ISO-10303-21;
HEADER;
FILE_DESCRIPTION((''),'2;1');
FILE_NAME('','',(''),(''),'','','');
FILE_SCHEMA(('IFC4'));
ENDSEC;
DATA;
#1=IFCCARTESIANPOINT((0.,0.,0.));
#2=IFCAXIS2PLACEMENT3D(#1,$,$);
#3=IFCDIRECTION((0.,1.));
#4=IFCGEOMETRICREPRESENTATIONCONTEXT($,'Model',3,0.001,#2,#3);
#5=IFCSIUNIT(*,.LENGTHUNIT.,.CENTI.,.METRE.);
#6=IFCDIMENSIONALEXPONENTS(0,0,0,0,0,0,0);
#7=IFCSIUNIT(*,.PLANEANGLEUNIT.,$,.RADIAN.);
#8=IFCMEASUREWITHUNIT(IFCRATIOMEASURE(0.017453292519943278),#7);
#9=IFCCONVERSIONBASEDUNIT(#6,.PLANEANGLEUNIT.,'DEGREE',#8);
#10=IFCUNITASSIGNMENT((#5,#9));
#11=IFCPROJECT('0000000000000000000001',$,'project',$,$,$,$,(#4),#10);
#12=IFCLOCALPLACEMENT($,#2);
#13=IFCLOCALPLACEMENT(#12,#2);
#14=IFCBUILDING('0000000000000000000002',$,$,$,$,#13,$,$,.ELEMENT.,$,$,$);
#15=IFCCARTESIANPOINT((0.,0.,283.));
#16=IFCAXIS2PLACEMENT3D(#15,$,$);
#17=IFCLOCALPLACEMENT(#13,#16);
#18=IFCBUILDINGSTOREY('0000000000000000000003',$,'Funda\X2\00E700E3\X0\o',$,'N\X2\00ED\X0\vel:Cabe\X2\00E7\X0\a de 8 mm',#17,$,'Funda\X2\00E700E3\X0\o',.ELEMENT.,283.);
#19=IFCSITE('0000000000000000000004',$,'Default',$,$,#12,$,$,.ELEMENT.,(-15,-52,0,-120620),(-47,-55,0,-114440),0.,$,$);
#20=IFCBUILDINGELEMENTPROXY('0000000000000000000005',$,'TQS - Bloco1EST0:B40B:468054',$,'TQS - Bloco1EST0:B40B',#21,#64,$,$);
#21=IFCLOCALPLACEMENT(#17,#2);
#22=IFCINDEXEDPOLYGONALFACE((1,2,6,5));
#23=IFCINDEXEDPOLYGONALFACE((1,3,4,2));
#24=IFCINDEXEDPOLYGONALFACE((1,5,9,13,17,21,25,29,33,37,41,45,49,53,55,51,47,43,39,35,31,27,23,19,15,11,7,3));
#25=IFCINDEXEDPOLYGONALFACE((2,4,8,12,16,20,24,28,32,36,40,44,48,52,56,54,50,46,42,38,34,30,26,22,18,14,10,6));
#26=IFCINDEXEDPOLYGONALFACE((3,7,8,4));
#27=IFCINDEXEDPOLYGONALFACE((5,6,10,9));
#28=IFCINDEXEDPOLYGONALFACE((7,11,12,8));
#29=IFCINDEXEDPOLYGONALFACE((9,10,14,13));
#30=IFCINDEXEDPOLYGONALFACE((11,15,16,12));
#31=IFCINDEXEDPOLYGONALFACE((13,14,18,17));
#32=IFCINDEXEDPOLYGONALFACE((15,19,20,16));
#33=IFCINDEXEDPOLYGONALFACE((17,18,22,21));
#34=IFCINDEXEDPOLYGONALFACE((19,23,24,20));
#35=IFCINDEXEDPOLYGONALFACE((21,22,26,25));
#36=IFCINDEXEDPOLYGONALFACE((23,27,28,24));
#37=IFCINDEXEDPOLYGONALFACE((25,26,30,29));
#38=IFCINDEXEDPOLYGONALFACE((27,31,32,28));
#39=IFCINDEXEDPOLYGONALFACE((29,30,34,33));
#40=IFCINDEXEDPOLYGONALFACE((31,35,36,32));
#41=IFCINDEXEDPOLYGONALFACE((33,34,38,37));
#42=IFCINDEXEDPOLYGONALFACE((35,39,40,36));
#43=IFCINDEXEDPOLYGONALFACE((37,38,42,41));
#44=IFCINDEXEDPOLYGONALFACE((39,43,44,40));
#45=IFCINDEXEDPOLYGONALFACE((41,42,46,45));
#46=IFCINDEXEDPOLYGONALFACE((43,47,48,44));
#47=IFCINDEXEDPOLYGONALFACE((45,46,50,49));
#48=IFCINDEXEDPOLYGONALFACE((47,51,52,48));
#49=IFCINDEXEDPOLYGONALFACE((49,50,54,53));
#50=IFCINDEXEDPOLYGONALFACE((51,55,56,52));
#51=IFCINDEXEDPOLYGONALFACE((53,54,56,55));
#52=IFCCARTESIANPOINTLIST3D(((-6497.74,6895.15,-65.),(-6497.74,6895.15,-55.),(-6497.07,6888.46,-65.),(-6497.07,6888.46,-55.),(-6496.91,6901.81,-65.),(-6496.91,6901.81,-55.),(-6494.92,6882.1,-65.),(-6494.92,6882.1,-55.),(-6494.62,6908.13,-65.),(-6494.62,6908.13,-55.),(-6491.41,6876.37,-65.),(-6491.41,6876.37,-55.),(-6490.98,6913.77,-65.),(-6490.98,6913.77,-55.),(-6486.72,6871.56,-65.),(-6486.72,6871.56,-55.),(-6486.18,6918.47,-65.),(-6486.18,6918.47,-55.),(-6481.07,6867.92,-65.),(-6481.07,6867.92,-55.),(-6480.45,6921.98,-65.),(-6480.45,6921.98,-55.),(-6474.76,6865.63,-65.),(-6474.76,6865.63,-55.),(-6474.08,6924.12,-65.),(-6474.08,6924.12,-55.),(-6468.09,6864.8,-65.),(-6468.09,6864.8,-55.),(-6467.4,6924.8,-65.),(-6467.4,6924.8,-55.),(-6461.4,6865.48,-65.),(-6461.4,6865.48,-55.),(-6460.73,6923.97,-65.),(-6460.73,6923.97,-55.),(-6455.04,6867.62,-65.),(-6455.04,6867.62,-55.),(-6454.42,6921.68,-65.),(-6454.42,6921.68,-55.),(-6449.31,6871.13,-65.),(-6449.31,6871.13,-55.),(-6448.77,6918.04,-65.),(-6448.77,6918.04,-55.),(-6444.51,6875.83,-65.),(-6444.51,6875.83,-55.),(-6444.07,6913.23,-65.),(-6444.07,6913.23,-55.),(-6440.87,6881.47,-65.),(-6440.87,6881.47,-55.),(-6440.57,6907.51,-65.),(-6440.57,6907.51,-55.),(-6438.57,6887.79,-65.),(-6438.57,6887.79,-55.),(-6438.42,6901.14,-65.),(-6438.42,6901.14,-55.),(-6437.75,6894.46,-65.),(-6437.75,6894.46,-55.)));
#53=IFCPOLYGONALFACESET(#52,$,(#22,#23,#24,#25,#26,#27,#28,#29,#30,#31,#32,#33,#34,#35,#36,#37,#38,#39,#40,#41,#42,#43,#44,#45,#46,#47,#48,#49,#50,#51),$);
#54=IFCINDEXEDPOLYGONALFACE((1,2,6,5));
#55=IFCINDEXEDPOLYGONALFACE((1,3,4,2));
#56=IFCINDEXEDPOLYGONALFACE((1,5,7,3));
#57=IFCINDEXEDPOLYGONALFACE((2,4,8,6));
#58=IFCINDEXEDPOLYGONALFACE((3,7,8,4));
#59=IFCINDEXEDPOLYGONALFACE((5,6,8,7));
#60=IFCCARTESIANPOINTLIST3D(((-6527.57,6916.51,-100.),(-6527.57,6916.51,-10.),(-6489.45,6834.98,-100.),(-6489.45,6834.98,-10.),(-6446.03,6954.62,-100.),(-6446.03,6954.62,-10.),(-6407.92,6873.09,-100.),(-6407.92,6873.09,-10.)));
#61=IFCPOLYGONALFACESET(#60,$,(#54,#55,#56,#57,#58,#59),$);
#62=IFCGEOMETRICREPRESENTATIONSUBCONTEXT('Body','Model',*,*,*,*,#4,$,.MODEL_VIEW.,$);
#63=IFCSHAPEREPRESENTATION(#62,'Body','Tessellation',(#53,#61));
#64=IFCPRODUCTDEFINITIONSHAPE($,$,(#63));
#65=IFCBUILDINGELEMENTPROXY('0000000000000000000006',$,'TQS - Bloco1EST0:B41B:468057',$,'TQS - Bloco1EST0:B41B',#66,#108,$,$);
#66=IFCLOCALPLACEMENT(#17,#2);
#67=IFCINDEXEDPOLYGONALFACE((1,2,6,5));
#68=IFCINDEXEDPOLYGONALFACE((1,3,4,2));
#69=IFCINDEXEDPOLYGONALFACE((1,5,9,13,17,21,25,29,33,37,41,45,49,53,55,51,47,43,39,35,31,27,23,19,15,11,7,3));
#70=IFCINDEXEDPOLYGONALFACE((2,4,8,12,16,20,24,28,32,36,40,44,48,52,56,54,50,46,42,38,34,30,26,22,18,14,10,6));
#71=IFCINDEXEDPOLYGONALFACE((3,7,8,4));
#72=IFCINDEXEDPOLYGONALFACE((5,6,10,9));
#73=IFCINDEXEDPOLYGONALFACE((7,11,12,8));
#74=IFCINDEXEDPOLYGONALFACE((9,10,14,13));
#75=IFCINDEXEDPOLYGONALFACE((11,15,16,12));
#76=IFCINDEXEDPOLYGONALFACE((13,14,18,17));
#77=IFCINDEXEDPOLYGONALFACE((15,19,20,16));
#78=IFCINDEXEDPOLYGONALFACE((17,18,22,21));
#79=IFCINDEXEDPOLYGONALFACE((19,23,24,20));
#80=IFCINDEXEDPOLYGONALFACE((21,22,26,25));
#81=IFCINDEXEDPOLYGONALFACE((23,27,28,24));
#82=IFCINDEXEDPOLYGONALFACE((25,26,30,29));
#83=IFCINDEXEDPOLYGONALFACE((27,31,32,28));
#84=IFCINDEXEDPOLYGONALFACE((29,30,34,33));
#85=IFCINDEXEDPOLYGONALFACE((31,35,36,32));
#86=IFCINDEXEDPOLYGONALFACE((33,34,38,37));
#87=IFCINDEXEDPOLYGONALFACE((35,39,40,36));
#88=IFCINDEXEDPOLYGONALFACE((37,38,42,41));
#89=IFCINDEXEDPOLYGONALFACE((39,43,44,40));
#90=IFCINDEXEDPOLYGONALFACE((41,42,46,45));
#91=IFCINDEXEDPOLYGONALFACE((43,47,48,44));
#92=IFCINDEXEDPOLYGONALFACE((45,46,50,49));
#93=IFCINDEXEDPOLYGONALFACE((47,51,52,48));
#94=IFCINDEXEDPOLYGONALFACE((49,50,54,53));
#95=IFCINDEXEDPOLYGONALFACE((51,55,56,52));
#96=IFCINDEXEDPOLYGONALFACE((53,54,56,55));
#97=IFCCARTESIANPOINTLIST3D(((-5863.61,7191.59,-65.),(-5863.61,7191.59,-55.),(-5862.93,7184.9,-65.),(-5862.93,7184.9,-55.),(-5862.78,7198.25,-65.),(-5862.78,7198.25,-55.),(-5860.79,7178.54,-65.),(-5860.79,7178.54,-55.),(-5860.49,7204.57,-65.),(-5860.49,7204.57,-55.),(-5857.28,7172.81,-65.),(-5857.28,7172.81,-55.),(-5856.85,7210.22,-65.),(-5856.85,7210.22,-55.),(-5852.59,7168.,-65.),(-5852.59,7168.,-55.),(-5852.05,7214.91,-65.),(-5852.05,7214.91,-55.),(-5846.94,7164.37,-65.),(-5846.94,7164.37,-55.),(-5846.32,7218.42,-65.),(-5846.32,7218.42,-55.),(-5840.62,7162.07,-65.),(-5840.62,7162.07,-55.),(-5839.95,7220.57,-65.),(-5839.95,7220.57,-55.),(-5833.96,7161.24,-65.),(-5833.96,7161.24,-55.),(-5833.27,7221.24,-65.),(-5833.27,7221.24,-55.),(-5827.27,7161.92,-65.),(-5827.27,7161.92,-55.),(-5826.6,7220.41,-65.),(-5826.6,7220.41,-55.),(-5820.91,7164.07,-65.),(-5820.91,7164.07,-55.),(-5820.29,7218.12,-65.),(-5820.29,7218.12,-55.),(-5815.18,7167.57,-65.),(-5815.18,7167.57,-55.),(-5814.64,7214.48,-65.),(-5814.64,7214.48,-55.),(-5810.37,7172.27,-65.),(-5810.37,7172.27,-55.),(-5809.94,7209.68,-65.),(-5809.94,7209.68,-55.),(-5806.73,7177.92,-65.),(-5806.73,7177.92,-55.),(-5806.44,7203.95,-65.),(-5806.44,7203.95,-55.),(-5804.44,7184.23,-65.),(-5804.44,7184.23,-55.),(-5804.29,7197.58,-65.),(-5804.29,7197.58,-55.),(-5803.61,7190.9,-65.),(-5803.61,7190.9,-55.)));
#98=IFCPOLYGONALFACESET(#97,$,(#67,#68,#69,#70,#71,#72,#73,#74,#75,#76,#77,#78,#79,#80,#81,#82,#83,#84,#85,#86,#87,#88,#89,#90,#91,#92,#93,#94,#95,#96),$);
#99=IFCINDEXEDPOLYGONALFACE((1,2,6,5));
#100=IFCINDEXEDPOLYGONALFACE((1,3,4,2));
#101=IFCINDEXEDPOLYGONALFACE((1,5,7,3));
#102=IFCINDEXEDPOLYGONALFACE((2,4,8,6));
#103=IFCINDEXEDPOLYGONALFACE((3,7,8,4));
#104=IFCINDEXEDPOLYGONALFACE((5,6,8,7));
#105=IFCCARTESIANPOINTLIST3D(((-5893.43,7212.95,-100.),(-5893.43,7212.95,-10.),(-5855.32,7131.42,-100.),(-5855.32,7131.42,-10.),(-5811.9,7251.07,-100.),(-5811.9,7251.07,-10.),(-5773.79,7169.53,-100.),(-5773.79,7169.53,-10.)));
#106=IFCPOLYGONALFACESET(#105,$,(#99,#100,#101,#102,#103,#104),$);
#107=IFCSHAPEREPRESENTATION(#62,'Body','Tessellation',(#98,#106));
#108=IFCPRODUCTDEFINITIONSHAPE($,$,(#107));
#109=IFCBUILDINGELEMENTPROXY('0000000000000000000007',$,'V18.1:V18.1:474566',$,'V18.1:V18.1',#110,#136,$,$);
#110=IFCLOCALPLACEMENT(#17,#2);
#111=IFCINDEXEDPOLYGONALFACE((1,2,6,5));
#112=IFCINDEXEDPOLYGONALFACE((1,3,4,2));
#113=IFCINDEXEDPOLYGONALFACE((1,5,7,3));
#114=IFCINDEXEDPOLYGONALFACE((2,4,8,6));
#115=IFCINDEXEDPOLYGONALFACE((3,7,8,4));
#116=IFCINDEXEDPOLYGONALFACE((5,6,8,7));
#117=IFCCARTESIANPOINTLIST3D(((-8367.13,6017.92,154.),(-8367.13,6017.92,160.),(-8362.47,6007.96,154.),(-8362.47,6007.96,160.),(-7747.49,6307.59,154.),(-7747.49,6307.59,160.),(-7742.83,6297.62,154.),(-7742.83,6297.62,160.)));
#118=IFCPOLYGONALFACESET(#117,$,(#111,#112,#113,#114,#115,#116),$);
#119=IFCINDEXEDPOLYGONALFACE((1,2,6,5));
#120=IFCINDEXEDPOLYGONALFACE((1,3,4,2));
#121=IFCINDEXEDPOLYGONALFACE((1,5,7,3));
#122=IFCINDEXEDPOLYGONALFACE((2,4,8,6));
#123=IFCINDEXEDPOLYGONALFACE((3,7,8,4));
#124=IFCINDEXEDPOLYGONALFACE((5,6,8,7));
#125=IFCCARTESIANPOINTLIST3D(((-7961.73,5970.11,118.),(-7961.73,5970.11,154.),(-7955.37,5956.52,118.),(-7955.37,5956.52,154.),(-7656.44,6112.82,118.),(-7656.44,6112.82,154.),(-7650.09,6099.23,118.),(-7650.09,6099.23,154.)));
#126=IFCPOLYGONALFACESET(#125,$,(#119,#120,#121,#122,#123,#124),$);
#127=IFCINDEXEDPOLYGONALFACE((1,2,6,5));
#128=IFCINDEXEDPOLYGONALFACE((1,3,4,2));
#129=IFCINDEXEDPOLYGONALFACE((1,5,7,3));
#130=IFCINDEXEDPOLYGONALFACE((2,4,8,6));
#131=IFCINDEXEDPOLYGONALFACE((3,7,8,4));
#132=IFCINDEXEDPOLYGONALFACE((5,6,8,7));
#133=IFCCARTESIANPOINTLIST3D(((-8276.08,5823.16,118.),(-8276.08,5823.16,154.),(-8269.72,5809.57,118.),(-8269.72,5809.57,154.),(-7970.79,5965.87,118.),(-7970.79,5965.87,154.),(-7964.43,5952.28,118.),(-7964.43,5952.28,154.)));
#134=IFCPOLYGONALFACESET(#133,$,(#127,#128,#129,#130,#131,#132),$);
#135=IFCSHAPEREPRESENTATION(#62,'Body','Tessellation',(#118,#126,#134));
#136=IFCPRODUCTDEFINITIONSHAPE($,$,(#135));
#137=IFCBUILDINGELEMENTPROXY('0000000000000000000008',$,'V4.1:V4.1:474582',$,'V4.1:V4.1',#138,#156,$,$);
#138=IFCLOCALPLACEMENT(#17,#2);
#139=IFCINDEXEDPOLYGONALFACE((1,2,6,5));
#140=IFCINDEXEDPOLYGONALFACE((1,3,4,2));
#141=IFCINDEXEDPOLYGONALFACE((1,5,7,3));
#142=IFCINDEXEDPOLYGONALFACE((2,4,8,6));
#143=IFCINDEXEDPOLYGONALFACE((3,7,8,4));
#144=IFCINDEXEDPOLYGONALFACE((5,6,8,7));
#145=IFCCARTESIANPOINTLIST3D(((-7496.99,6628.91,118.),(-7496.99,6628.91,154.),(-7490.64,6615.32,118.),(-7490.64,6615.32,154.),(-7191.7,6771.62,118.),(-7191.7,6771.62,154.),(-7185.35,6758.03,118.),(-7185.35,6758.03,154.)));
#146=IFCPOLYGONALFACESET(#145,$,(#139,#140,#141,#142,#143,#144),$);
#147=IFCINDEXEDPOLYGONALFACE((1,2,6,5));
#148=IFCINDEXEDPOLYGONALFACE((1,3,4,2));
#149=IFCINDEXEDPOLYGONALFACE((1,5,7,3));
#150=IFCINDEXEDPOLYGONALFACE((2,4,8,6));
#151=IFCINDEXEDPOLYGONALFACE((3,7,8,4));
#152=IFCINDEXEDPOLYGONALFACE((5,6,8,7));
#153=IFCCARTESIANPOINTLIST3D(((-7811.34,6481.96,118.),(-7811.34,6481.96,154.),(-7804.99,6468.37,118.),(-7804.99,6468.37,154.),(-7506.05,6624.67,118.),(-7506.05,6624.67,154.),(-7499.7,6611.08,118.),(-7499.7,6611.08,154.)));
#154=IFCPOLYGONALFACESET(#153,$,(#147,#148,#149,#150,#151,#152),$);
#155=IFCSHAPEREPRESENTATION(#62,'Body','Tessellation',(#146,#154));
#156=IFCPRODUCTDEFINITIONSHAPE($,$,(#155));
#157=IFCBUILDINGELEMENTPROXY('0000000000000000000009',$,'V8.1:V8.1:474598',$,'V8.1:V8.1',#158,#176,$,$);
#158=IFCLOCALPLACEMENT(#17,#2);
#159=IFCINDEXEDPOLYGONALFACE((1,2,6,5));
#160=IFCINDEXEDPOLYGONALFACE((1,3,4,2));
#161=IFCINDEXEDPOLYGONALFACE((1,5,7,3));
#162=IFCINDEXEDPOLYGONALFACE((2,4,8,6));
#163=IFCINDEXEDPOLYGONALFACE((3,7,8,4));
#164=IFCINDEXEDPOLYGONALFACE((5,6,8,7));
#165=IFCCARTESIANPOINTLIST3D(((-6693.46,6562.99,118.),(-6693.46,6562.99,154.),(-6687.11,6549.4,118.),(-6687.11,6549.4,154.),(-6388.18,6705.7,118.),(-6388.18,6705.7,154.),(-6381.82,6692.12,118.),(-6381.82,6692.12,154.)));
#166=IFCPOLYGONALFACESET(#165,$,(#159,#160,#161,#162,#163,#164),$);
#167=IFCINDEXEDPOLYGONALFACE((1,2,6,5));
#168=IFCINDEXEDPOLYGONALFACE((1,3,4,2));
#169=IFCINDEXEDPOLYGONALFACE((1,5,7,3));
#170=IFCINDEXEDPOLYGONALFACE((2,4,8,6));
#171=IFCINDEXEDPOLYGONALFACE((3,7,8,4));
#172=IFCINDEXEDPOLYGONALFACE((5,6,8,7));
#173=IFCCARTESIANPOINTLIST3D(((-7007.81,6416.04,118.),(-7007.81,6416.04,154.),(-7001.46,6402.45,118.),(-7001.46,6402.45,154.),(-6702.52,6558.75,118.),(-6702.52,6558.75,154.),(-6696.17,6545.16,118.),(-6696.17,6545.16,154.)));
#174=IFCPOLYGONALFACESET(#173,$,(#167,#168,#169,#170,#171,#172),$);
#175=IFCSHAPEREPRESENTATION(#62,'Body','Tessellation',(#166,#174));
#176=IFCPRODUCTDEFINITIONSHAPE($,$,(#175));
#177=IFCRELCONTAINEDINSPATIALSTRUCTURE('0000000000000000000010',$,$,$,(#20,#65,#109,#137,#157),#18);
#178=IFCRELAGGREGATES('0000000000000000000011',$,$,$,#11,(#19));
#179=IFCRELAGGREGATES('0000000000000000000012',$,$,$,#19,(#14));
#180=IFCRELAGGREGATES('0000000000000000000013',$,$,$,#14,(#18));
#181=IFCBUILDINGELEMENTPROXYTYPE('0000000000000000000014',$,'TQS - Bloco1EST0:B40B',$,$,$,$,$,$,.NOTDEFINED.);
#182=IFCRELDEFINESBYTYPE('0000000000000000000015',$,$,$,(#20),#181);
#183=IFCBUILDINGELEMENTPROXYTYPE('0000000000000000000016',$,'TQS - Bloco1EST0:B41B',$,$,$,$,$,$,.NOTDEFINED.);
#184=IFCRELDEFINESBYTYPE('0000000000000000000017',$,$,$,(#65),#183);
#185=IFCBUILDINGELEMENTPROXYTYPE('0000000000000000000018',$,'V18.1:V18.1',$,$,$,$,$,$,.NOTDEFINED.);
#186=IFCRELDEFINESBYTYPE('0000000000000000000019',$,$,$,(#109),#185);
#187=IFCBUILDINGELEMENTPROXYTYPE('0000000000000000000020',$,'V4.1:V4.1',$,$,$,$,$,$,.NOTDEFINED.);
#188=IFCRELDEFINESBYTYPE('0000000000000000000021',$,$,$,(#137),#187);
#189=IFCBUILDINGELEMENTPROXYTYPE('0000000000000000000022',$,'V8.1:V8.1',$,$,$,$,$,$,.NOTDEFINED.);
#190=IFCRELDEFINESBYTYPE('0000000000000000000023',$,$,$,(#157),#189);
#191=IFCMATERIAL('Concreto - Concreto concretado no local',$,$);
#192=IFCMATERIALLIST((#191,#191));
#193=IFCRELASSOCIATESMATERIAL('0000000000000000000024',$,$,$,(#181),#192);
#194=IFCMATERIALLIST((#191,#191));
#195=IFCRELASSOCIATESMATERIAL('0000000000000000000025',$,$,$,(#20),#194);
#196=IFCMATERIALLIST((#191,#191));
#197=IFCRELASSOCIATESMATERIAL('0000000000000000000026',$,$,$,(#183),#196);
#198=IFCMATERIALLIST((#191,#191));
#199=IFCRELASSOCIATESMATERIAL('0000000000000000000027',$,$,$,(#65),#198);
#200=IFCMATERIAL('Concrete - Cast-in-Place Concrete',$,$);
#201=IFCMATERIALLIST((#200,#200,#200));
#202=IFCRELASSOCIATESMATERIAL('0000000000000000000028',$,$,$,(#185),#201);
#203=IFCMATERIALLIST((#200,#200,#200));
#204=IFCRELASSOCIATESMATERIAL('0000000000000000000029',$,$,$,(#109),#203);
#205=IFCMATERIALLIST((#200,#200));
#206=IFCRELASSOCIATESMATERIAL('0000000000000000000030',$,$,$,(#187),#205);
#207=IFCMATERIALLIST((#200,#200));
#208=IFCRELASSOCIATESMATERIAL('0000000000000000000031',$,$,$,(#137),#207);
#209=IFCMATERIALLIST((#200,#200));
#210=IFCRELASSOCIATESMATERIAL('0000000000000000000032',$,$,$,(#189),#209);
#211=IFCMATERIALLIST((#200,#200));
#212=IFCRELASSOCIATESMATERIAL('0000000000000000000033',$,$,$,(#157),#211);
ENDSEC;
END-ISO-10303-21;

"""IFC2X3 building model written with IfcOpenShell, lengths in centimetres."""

from ifc_helpers import new_model, entity, si_unit, converted_unit, direction, frame, frame_2d, origin, origin_2d_with_axis, place, context, subcontext, project, spatial, rectangle, circle, extrude, source, transform, mapped, material, material_list, type_object, type_shapes, element, save


model = new_model("IFC2X3")

# Units and contexts
model_context = context("Model", 3, precision=0.001, world=origin(), true_north=direction((0.0, 1.0)))
body_context = subcontext(model_context, "Body", "Model", "MODEL_VIEW")
ifc_project = project(units=[si_unit("LENGTHUNIT", "METRE", prefix="CENTI"), converted_unit("PLANEANGLEUNIT", "DEGREE", entity("IfcRatioMeasure", 0.017453292519943278), si_unit("PLANEANGLEUNIT", "RADIAN"), dimensions=[0, 0, 0, 0, 0, 0, 0])], contexts=[model_context])

# Site, building, storey
site_placement = place(None, origin())
site = spatial("IfcSite", under=ifc_project, at=site_placement, Name="Default", CompositionType="ELEMENT", RefLatitude=(-15, -52, 0, -120620), RefLongitude=(-47, -55, 0, -114440), RefElevation=0.0)
building_placement = place(site_placement, origin())
building = spatial("IfcBuilding", under=site, at=building_placement, CompositionType="ELEMENT")
storey_placement = place(building_placement, frame((0.0, 0.0, 283.0)))
storey = spatial("IfcBuildingStorey", under=building, at=storey_placement, Name="Fundação", ObjectType="Nível:Cabeça de 8 mm", LongName="Fundação", CompositionType="ELEMENT", Elevation=283.0)

# Building element proxies
ifc_material_1 = material(Name="Concreto - Concreto concretado no local")
ifc_material_list_1 = material_list([ifc_material_1, ifc_material_1])
ifc_material_list_2 = material_list([ifc_material_1, ifc_material_1])
building_element_proxy_type_1 = type_object("IfcBuildingElementProxyType", Name="TQS - Bloco1EST0:B40B", PredefinedType="NOTDEFINED", material=ifc_material_list_2)
shared_shape_1 = source(origin(), body_context, "Body", "SweptSolid", [
    extrude(circle(Radius=30.0, at=frame_2d((0.0, 0.0), x_axis=(1.0, 0.0))), frame((0.0, 0.0, -55.0)), (0.0, 0.0, 1.0), 10.0),
    extrude(rectangle(XDim=90.0, YDim=90.0, at=origin_2d_with_axis()), frame((0.0, 0.0, -90.0), z_axis=(0.0, 0.0, 1.0), x_axis=(-1.0, 0.0, 0.0)), (0.0, 0.0, 1.0), 90.0),
])
type_shapes(building_element_proxy_type_1, [shared_shape_1])
proxy_1_placement = place(storey_placement, frame((-6467.74, 6894.8, -10.0), z_axis=(0.0, 0.0, 1.0), x_axis=(0.905902, 0.423488, 0.0)))
element("IfcBuildingElementProxy", 1, at=proxy_1_placement, inside=storey, type_object=building_element_proxy_type_1, material=ifc_material_list_1, Name="TQS - Bloco1EST0:B40B:468054", ObjectType="TQS - Bloco1EST0:B40B", context=body_context, shape_type="MappedRepresentation", body=[
    mapped(shared_shape_1, transform((0.0, 0.0, 0.0), scale=1.0)),
])
ifc_material_list_3 = material_list([ifc_material_1, ifc_material_1])
ifc_material_list_4 = material_list([ifc_material_1, ifc_material_1])
building_element_proxy_type_2 = type_object("IfcBuildingElementProxyType", Name="TQS - Bloco1EST0:B41B", PredefinedType="NOTDEFINED", material=ifc_material_list_4)
shared_shape_2 = source(origin(), body_context, "Body", "SweptSolid", [
    extrude(circle(Radius=30.0, at=frame_2d((0.0, 0.0), x_axis=(1.0, 0.0))), frame((0.0, 0.0, -55.0)), (0.0, 0.0, 1.0), 10.0),
    extrude(rectangle(XDim=90.0, YDim=90.0, at=origin_2d_with_axis()), frame((0.0, 0.0, -90.0), z_axis=(0.0, 0.0, 1.0), x_axis=(-1.0, 0.0, 0.0)), (0.0, 0.0, 1.0), 90.0),
])
type_shapes(building_element_proxy_type_2, [shared_shape_2])
proxy_2_placement = place(storey_placement, frame((-5833.61, 7191.24, -10.0), z_axis=(0.0, 0.0, 1.0), x_axis=(0.905902, 0.423488, 0.0)))
element("IfcBuildingElementProxy", 2, at=proxy_2_placement, inside=storey, type_object=building_element_proxy_type_2, material=ifc_material_list_3, Name="TQS - Bloco1EST0:B41B:468057", ObjectType="TQS - Bloco1EST0:B41B", context=body_context, shape_type="MappedRepresentation", body=[
    mapped(shared_shape_2, transform((0.0, 0.0, 0.0), scale=1.0)),
])
ifc_material_2 = material(Name="Concrete - Cast-in-Place Concrete")
ifc_material_list_5 = material_list([ifc_material_2, ifc_material_2, ifc_material_2])
ifc_material_list_6 = material_list([ifc_material_2, ifc_material_2, ifc_material_2])
building_element_proxy_type_3 = type_object("IfcBuildingElementProxyType", Name="V18.1:V18.1", PredefinedType="NOTDEFINED", material=ifc_material_list_6)
shared_shape_3 = source(origin(), body_context, "Body", "SweptSolid", [
    extrude(rectangle(XDim=11.0, YDim=684.0, at=frame_2d((0.0, 0.0), x_axis=(1.0, 0.0))), frame((312.15, 348.21, 36.0), z_axis=(0.0, 0.0, 1.0), x_axis=(0.423488, -0.905902, 0.0)), (0.0, 0.0, 1.0), 6.0),
    extrude(rectangle(XDim=15.0, YDim=337.0, at=frame_2d((0.0, 0.0), x_axis=(1.0, 0.0))), frame((561.22, 225.1, 0.0), z_axis=(0.0, 0.0, 1.0), x_axis=(-0.423488, 0.905902, 0.0)), (0.0, 0.0, 1.0), 36.0),
    extrude(rectangle(XDim=337.0, YDim=15.0, at=frame_2d((0.0, 0.0), x_axis=(1.0, 0.0))), frame((246.87, 78.15, 0.0), z_axis=(0.0, 0.0, 1.0), x_axis=(-0.905902, -0.423488, 0.0)), (0.0, 0.0, 1.0), 36.0),
])
type_shapes(building_element_proxy_type_3, [shared_shape_3])
proxy_3_placement = place(storey_placement, frame((-8367.13, 5809.57, 118.0)))
element("IfcBuildingElementProxy", 3, at=proxy_3_placement, inside=storey, type_object=building_element_proxy_type_3, material=ifc_material_list_5, Name="V18.1:V18.1:474566", ObjectType="V18.1:V18.1", context=body_context, shape_type="MappedRepresentation", body=[
    mapped(shared_shape_3, transform((0.0, 0.0, 0.0), scale=1.0)),
])
ifc_material_list_7 = material_list([ifc_material_2, ifc_material_2])
ifc_material_list_8 = material_list([ifc_material_2, ifc_material_2])
building_element_proxy_type_4 = type_object("IfcBuildingElementProxyType", Name="V4.1:V4.1", PredefinedType="NOTDEFINED", material=ifc_material_list_8)
shared_shape_4 = source(origin(), body_context, "Body", "SweptSolid", [
    extrude(rectangle(XDim=15.0, YDim=337.0, at=frame_2d((0.0, 0.0), x_axis=(1.0, 0.0))), frame((470.17, 225.1, 0.0), z_axis=(0.0, 0.0, 1.0), x_axis=(-0.423488, 0.905902, 0.0)), (0.0, 0.0, 1.0), 36.0),
    extrude(rectangle(XDim=337.0, YDim=15.0, at=frame_2d((0.0, 0.0), x_axis=(1.0, 0.0))), frame((155.82, 78.15, 0.0), z_axis=(0.0, 0.0, 1.0), x_axis=(-0.905902, -0.423488, 0.0)), (0.0, 0.0, 1.0), 36.0),
])
type_shapes(building_element_proxy_type_4, [shared_shape_4])
proxy_4_placement = place(storey_placement, frame((-7811.34, 6468.37, 118.0)))
element("IfcBuildingElementProxy", 4, at=proxy_4_placement, inside=storey, type_object=building_element_proxy_type_4, material=ifc_material_list_7, Name="V4.1:V4.1:474582", ObjectType="V4.1:V4.1", context=body_context, shape_type="MappedRepresentation", body=[
    mapped(shared_shape_4, transform((0.0, 0.0, 0.0), scale=1.0)),
])
ifc_material_list_9 = material_list([ifc_material_2, ifc_material_2])
ifc_material_list_10 = material_list([ifc_material_2, ifc_material_2])
building_element_proxy_type_5 = type_object("IfcBuildingElementProxyType", Name="V8.1:V8.1", PredefinedType="NOTDEFINED", material=ifc_material_list_10)
shared_shape_5 = source(origin(), body_context, "Body", "SweptSolid", [
    extrude(rectangle(XDim=15.0, YDim=337.0, at=frame_2d((0.0, 0.0), x_axis=(1.0, 0.0))), frame((470.17, 225.1, 0.0), z_axis=(0.0, 0.0, 1.0), x_axis=(-0.423488, 0.905902, 0.0)), (0.0, 0.0, 1.0), 36.0),
    extrude(rectangle(XDim=337.0, YDim=15.0, at=frame_2d((0.0, 0.0), x_axis=(1.0, 0.0))), frame((155.82, 78.15, 0.0), z_axis=(0.0, 0.0, 1.0), x_axis=(-0.905902, -0.423488, 0.0)), (0.0, 0.0, 1.0), 36.0),
])
type_shapes(building_element_proxy_type_5, [shared_shape_5])
proxy_5_placement = place(storey_placement, frame((-7007.81, 6402.45, 118.0)))
element("IfcBuildingElementProxy", 5, at=proxy_5_placement, inside=storey, type_object=building_element_proxy_type_5, material=ifc_material_list_9, Name="V8.1:V8.1:474598", ObjectType="V8.1:V8.1", context=body_context, shape_type="MappedRepresentation", body=[
    mapped(shared_shape_5, transform((0.0, 0.0, 0.0), scale=1.0)),
])

save(model, "model.ifc")
